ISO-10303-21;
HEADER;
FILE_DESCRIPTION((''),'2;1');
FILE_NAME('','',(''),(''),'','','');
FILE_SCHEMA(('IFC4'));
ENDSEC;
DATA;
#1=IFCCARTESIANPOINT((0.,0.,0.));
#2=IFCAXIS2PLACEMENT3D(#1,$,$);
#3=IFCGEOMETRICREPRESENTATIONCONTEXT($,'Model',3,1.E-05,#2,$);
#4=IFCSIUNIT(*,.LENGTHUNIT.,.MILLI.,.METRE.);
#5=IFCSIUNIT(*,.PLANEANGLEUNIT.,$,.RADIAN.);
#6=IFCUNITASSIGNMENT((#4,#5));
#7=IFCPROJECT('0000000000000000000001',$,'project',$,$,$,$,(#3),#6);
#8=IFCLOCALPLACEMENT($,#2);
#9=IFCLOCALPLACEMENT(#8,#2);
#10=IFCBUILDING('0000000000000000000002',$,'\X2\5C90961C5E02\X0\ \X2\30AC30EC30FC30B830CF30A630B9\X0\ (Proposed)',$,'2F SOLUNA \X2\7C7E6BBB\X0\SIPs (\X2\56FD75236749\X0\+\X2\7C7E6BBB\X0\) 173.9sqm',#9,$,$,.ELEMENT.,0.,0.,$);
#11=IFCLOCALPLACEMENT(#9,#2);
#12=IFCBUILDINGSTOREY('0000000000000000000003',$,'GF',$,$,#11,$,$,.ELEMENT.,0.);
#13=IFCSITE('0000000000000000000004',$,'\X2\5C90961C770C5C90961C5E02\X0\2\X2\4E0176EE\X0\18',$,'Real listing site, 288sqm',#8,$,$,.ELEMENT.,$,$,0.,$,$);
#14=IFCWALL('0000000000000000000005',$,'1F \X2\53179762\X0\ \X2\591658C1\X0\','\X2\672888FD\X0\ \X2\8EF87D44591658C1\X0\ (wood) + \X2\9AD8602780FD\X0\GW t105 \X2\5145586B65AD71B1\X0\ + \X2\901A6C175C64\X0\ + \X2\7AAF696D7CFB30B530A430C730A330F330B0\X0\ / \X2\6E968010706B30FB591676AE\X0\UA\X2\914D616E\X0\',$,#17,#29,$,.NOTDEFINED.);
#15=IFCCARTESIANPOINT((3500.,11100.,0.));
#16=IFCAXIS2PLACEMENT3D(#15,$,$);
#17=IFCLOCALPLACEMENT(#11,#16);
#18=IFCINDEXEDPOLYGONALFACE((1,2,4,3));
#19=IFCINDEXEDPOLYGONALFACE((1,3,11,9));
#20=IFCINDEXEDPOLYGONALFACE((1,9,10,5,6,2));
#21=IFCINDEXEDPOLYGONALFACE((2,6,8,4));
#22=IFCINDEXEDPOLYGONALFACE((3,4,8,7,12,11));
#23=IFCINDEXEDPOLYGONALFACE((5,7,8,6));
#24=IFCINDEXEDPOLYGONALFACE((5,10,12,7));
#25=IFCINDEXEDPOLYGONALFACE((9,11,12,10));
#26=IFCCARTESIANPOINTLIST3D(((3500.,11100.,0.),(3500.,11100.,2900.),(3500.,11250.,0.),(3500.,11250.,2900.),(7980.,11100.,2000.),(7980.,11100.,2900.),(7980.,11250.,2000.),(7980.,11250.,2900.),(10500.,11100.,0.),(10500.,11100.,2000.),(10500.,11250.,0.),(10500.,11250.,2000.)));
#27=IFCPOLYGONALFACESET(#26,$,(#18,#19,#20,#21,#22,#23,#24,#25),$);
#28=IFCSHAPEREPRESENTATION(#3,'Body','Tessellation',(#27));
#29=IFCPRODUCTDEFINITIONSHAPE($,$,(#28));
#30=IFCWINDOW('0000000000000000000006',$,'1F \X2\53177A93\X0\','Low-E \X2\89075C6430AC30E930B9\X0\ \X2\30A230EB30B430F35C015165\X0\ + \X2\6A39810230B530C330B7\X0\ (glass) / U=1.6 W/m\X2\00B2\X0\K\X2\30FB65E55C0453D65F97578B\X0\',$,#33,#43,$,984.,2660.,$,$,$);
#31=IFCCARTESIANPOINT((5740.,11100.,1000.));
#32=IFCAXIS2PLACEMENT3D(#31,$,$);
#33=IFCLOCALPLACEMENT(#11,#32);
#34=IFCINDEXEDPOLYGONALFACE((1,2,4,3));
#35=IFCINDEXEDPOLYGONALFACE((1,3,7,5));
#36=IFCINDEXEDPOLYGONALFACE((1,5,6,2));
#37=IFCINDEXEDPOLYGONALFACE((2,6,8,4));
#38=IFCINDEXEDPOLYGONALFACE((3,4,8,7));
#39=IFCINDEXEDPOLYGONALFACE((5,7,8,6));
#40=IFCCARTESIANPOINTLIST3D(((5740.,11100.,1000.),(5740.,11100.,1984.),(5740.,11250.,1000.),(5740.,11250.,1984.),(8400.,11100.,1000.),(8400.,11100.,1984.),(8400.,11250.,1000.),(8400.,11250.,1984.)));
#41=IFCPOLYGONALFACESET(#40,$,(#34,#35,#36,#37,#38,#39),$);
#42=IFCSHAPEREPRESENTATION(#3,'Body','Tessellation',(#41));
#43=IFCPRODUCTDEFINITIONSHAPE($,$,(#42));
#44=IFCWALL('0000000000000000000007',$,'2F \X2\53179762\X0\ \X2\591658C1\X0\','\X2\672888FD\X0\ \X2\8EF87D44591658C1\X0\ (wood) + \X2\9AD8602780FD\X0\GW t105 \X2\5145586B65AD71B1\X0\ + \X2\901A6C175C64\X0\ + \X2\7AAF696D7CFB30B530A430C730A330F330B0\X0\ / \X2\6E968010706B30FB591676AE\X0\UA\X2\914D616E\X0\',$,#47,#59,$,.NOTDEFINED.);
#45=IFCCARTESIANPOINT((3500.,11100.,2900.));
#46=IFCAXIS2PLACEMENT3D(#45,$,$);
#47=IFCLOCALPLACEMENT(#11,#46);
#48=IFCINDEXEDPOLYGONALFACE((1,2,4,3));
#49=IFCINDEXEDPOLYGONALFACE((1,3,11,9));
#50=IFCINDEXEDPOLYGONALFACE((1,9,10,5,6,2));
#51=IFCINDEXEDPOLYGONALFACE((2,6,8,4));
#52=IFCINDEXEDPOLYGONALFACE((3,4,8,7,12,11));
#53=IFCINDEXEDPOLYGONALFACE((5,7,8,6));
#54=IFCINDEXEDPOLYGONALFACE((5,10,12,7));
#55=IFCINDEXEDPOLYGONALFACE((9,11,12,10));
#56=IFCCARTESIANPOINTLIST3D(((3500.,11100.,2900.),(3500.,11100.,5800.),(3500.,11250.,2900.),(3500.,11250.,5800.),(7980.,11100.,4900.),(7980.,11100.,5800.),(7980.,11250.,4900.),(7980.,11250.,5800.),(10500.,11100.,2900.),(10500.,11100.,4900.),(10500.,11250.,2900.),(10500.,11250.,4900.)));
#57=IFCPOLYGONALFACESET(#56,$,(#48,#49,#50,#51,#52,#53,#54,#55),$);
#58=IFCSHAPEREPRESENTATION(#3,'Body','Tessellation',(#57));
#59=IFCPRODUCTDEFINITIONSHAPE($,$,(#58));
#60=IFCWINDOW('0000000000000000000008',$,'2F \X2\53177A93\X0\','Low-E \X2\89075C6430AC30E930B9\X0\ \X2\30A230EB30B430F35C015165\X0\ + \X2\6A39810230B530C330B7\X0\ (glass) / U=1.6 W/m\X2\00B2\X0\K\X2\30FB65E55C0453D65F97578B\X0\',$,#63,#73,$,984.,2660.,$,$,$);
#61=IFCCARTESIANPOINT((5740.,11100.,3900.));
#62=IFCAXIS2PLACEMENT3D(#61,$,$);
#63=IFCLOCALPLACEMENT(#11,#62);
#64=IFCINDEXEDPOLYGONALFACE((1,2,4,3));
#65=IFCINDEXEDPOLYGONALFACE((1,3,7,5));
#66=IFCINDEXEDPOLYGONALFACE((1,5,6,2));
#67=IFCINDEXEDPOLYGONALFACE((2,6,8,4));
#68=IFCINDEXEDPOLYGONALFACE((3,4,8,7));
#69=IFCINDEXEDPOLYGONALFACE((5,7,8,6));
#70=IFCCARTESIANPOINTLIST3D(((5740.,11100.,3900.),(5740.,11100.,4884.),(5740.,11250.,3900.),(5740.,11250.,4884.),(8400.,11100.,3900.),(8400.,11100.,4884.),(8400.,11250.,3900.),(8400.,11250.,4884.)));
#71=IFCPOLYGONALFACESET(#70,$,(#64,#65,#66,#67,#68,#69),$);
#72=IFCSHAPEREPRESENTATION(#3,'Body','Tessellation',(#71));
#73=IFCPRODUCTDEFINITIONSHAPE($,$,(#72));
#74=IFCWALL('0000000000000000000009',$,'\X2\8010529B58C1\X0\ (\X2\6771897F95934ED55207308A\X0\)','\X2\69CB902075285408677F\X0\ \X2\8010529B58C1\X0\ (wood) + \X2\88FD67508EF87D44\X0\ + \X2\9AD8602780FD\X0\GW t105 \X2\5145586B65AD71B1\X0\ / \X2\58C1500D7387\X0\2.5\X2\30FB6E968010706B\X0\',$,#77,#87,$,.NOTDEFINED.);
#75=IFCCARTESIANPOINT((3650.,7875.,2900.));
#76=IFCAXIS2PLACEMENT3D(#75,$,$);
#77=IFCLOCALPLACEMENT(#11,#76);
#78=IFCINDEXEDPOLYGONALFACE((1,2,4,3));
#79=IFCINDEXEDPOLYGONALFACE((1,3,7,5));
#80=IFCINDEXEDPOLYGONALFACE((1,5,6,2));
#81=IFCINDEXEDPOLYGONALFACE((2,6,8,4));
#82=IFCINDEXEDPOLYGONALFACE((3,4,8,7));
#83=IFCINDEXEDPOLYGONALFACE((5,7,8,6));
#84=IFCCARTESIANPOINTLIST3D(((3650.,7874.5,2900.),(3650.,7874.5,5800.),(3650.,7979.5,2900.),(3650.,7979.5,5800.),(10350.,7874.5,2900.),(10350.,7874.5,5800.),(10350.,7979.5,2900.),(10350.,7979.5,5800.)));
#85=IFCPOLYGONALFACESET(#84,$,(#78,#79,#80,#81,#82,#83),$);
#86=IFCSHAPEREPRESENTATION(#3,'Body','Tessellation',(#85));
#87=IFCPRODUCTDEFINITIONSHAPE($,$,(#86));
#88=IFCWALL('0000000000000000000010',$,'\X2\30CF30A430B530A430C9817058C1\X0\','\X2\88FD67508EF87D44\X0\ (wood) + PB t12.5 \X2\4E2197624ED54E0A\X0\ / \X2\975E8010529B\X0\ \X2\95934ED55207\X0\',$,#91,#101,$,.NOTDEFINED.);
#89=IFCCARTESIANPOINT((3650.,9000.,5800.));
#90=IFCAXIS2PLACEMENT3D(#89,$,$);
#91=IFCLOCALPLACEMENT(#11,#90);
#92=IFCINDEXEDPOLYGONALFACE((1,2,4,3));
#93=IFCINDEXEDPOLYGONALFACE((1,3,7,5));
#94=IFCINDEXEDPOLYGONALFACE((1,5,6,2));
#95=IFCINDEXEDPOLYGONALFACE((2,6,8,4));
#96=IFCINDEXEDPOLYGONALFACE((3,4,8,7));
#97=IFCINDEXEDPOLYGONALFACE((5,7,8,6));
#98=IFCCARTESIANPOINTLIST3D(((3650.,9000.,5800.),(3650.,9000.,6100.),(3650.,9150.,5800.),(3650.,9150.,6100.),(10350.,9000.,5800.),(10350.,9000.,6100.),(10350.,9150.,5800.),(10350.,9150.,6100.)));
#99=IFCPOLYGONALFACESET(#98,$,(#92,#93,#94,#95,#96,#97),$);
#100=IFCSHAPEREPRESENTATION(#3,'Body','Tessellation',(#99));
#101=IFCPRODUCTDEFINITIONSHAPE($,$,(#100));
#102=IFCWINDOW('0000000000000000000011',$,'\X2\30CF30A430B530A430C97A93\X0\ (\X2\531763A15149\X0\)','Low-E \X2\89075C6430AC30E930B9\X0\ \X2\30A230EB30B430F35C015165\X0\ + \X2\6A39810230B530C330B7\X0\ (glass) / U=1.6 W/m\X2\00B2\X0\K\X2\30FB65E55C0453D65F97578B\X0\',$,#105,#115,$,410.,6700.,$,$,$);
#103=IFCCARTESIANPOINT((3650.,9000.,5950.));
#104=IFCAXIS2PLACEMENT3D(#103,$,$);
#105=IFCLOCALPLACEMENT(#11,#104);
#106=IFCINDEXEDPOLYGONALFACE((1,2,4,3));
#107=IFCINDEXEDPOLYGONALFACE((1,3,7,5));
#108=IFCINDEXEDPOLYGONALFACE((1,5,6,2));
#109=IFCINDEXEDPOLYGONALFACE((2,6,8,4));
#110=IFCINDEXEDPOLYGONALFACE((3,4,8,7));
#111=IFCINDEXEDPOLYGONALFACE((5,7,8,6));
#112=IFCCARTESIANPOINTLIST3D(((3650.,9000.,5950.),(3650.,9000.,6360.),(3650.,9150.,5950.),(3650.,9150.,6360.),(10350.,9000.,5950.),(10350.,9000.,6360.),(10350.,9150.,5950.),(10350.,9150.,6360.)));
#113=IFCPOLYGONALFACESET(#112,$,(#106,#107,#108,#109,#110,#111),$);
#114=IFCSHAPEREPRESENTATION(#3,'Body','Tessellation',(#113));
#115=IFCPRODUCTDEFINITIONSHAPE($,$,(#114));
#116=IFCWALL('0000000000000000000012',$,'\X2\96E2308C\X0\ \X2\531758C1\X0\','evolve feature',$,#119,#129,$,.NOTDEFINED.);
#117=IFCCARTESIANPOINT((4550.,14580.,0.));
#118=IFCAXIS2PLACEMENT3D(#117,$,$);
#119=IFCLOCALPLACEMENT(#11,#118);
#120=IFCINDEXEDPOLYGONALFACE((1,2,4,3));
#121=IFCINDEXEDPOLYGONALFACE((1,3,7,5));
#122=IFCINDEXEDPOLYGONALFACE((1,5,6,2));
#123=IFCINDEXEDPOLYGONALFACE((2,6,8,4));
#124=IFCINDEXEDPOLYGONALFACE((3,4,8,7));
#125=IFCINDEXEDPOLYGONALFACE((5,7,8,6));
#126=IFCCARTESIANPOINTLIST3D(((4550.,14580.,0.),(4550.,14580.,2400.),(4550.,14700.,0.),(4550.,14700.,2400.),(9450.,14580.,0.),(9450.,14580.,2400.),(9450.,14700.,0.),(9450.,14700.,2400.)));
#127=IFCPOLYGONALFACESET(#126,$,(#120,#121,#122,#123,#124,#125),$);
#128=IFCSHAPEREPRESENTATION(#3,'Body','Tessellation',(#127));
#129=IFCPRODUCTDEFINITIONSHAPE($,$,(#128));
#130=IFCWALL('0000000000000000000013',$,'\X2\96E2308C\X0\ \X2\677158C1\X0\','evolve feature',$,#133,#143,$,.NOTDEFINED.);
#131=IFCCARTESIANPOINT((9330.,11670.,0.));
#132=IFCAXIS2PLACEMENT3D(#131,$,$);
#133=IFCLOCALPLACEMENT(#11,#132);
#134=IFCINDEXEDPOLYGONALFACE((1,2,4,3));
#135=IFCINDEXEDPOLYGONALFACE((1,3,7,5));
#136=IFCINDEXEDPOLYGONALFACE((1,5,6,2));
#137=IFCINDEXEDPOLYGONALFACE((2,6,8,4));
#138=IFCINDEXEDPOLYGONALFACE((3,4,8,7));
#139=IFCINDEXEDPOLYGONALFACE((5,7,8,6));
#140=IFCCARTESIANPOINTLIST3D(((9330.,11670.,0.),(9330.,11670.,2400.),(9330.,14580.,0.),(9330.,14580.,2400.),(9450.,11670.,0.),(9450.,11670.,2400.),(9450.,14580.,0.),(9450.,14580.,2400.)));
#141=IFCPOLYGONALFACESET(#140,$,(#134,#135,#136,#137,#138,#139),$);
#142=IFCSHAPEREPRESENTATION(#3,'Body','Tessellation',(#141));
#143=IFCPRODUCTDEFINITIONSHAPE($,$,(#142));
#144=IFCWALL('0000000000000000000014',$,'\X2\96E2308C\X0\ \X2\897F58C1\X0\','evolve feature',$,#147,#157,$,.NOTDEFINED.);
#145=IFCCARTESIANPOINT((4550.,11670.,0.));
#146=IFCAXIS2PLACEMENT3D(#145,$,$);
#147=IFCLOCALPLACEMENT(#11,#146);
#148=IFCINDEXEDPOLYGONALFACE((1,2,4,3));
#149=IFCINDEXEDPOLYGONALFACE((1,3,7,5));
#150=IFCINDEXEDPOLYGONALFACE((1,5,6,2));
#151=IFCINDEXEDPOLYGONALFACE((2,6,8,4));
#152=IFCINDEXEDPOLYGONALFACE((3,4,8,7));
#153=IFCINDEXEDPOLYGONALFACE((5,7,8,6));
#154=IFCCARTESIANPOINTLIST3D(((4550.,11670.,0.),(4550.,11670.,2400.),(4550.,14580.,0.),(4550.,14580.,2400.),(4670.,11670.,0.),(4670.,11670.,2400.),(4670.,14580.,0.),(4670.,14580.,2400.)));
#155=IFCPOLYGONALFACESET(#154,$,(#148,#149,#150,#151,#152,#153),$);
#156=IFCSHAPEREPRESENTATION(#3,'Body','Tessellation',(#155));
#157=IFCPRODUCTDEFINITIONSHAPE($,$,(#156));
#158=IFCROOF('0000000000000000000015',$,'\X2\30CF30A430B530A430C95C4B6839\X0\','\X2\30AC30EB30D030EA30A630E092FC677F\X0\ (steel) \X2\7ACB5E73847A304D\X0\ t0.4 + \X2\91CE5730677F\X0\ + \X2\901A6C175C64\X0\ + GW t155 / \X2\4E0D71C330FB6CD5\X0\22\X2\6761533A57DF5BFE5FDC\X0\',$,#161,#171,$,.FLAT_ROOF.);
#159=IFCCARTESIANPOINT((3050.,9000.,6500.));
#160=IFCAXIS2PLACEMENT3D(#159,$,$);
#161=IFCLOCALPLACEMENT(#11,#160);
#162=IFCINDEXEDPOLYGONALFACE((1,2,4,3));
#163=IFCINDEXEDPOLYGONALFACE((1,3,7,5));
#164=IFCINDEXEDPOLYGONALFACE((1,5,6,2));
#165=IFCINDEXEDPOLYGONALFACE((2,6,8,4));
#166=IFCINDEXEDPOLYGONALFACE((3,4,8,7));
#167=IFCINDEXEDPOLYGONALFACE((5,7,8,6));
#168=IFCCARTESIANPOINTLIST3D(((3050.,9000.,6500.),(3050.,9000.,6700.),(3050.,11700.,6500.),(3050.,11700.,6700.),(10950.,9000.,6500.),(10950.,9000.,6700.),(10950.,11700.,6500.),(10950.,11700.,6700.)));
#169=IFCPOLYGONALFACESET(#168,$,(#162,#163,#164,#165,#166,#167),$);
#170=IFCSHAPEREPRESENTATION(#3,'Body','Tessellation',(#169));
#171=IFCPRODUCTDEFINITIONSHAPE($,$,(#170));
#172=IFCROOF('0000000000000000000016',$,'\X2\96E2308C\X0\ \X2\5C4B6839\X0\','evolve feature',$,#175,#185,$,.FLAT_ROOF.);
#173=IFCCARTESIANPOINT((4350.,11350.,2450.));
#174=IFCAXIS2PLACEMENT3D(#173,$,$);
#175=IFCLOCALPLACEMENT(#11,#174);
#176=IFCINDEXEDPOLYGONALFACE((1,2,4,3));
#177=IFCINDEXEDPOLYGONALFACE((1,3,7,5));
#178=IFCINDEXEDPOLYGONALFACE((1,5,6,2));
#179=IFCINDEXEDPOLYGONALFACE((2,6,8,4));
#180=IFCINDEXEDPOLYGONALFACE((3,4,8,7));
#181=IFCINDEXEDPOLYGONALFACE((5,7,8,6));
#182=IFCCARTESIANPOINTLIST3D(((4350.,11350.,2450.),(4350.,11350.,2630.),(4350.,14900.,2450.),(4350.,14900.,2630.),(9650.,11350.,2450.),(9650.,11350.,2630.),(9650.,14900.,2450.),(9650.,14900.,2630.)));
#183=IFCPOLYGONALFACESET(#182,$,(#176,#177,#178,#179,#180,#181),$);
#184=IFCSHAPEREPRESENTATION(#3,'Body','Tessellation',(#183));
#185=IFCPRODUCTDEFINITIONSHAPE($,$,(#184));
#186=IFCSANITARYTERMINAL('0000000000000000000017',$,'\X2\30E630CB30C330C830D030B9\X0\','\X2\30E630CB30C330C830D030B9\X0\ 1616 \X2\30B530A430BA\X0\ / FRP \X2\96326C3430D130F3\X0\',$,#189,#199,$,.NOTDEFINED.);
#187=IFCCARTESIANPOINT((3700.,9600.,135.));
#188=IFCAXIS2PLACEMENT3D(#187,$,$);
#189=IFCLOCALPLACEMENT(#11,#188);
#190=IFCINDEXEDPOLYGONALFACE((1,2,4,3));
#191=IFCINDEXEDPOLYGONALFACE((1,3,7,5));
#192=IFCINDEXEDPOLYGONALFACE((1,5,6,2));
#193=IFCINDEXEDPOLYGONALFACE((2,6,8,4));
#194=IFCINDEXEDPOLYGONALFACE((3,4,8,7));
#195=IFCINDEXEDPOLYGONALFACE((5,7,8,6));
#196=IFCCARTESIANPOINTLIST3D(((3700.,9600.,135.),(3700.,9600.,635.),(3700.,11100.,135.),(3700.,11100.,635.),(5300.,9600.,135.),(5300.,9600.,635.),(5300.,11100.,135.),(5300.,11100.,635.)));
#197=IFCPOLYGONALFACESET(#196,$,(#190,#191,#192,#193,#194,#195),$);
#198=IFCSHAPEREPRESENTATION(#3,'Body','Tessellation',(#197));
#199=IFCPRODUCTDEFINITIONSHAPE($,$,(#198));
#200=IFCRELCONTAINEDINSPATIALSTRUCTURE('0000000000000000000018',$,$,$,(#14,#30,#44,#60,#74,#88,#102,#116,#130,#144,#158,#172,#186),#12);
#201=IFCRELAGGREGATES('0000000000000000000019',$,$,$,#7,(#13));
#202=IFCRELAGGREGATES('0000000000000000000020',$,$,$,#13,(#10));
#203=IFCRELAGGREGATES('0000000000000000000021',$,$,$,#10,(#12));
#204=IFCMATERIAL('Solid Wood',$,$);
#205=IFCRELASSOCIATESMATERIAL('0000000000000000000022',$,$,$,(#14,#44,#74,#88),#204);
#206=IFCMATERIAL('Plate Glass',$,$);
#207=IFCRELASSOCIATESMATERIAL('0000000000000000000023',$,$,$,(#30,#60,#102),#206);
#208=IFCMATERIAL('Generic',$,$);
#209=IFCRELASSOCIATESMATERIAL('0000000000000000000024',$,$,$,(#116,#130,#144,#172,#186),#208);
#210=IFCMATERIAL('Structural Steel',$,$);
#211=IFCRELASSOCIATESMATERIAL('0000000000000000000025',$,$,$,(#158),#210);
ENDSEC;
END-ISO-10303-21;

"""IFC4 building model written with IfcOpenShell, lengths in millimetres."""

from ifc_helpers import new_model, si_unit, frame, frame_2d, origin, place, context, project, spatial, rectangle, extrude, material, element, fill, save


model = new_model("IFC4")

# Units and contexts
model_context = context("Model", 3, precision=1e-05, world=origin())
ifc_project = project(units=[si_unit("LENGTHUNIT", "METRE", prefix="MILLI"), si_unit("PLANEANGLEUNIT", "RADIAN")], contexts=[model_context])

# Site, building, storey
site_placement = place(None, origin())
site = spatial("IfcSite", under=ifc_project, at=site_placement, Name="岐阜県岐阜市2丁目18", ObjectType="Real listing site, 288sqm", CompositionType="ELEMENT", RefElevation=0.0)
building_placement = place(site_placement, origin())
building = spatial("IfcBuilding", under=site, at=building_placement, Name="岐阜市 ガレージハウス (Proposed)", ObjectType="2F SOLUNA 籾殻SIPs (国産杉+籾殻) 173.9sqm", CompositionType="ELEMENT", ElevationOfRefHeight=0.0, ElevationOfTerrain=0.0)
storey_placement = place(building_placement, origin())
storey = spatial("IfcBuildingStorey", under=building, at=storey_placement, Name="GF", CompositionType="ELEMENT", Elevation=0.0)

# Shared definitions
ifc_material_1 = material(Name="Generic")

# Wall, opening, window
ifc_material_2 = material(Name="Solid Wood")
wall_1_placement = place(storey_placement, frame((3500.0, 11100.0, 0.0)))
wall_1 = element("IfcWall", 1, at=wall_1_placement, inside=storey, material=ifc_material_2, Name="1F 北面 外壁", Description="木製 軸組外壁 (wood) + 高性能GW t105 充填断熱 + 通気層 + 窯業系サイディング / 準耐火・外皮UA配慮", PredefinedType="NOTDEFINED", context=model_context, shape_type="SweptSolid", body=[
    extrude(rectangle(XDim=7000.0, YDim=150.0, at=frame_2d((3500.0, 75.0))), frame((3500.0, 11100.0, 0.0)), (0.0, 0.0, 1.0), 2900.0),
])
opening_1_placement = place(storey_placement, frame((5740.0, 11100.0, 1000.0)))
opening_1 = element("IfcOpeningElement", 2, at=opening_1_placement, cuts=wall_1, PredefinedType="NOTDEFINED", context=model_context, shape_type="SweptSolid", body=[
    extrude(rectangle(XDim=2660.0, YDim=150.0, at=frame_2d((1330.0, 75.0))), frame((5740.0, 11100.0, 1000.0)), (0.0, 0.0, 1.0), 984.0),
])
ifc_material_3 = material(Name="Plate Glass")
window_1_placement = place(storey_placement, frame((5740.0, 11100.0, 1000.0)))
window_1 = element("IfcWindow", 3, at=window_1_placement, inside=storey, material=ifc_material_3, Name="1F 北窓", Description="Low-E 複層ガラス アルゴン封入 + 樹脂サッシ (glass) / U=1.6 W/m²K・日射取得型", OverallHeight=984.0, OverallWidth=2660.0, context=model_context, shape_type="SweptSolid", body=[
    extrude(rectangle(XDim=2660.0, YDim=150.0, at=frame_2d((1330.0, 75.0))), frame((5740.0, 11100.0, 1000.0)), (0.0, 0.0, 1.0), 984.0),
])
fill(opening_1, window_1)

# Wall, opening, window
wall_2_placement = place(storey_placement, frame((3500.0, 11100.0, 2900.0)))
wall_2 = element("IfcWall", 4, at=wall_2_placement, inside=storey, material=ifc_material_2, Name="2F 北面 外壁", Description="木製 軸組外壁 (wood) + 高性能GW t105 充填断熱 + 通気層 + 窯業系サイディング / 準耐火・外皮UA配慮", PredefinedType="NOTDEFINED", context=model_context, shape_type="SweptSolid", body=[
    extrude(rectangle(XDim=7000.0, YDim=150.0, at=frame_2d((3500.0, 75.0))), frame((3500.0, 11100.0, 2900.0)), (0.0, 0.0, 1.0), 2900.0),
])
opening_2_placement = place(storey_placement, frame((5740.0, 11100.0, 3900.0)))
opening_2 = element("IfcOpeningElement", 5, at=opening_2_placement, cuts=wall_2, PredefinedType="NOTDEFINED", context=model_context, shape_type="SweptSolid", body=[
    extrude(rectangle(XDim=2660.0, YDim=150.0, at=frame_2d((1330.0, 75.0))), frame((5740.0, 11100.0, 3900.0)), (0.0, 0.0, 1.0), 984.0),
])
window_2_placement = place(storey_placement, frame((5740.0, 11100.0, 3900.0)))
window_2 = element("IfcWindow", 6, at=window_2_placement, inside=storey, material=ifc_material_3, Name="2F 北窓", Description="Low-E 複層ガラス アルゴン封入 + 樹脂サッシ (glass) / U=1.6 W/m²K・日射取得型", OverallHeight=984.0, OverallWidth=2660.0, context=model_context, shape_type="SweptSolid", body=[
    extrude(rectangle(XDim=2660.0, YDim=150.0, at=frame_2d((1330.0, 75.0))), frame((5740.0, 11100.0, 3900.0)), (0.0, 0.0, 1.0), 984.0),
])
fill(opening_2, window_2)

# Wall
wall_3_placement = place(storey_placement, frame((3650.0, 7875.0, 2900.0)))
element("IfcWall", 7, at=wall_3_placement, inside=storey, material=ifc_material_2, Name="耐力壁 (東西間仕切り)", Description="構造用合板 耐力壁 (wood) + 製材軸組 + 高性能GW t105 充填断熱 / 壁倍率2.5・準耐火", PredefinedType="NOTDEFINED", context=model_context, shape_type="SweptSolid", body=[
    extrude(rectangle(XDim=6700.0, YDim=105.0, at=frame_2d((3350.0, 52.0))), frame((3650.0, 7875.0, 2900.0)), (0.0, 0.0, 1.0), 2900.0),
])

# Wall, opening, window
wall_4_placement = place(storey_placement, frame((3650.0, 9000.0, 5800.0)))
wall_4 = element("IfcWall", 8, at=wall_4_placement, inside=storey, material=ifc_material_2, Name="ハイサイド腰壁", Description="製材軸組 (wood) + PB t12.5 両面仕上 / 非耐力 間仕切", PredefinedType="NOTDEFINED", context=model_context, shape_type="SweptSolid", body=[
    extrude(rectangle(XDim=6700.0, YDim=150.0, at=frame_2d((3350.0, 75.0))), frame((3650.0, 9000.0, 5800.0)), (0.0, 0.0, 1.0), 700.0),
])
opening_3_placement = place(storey_placement, frame((3650.0, 9000.0, 5950.0)))
opening_3 = element("IfcOpeningElement", 9, at=opening_3_placement, cuts=wall_4, PredefinedType="NOTDEFINED", context=model_context, shape_type="SweptSolid", body=[
    extrude(rectangle(XDim=6700.0, YDim=150.0, at=frame_2d((3350.0, 75.0))), frame((3650.0, 9000.0, 5950.0)), (0.0, 0.0, 1.0), 410.0),
])
window_3_placement = place(storey_placement, frame((3650.0, 9000.0, 5950.0)))
window_3 = element("IfcWindow", 10, at=window_3_placement, inside=storey, material=ifc_material_3, Name="ハイサイド窓 (北採光)", Description="Low-E 複層ガラス アルゴン封入 + 樹脂サッシ (glass) / U=1.6 W/m²K・日射取得型", OverallHeight=410.0, OverallWidth=6700.0, context=model_context, shape_type="SweptSolid", body=[
    extrude(rectangle(XDim=6700.0, YDim=150.0, at=frame_2d((3350.0, 75.0))), frame((3650.0, 9000.0, 5950.0)), (0.0, 0.0, 1.0), 410.0),
])
fill(opening_3, window_3)

# Walls
wall_5_placement = place(storey_placement, frame((4550.0, 14580.0, 0.0)))
element("IfcWall", 11, at=wall_5_placement, inside=storey, material=ifc_material_1, Name="離れ 北壁", Description="evolve feature", PredefinedType="NOTDEFINED", context=model_context, shape_type="SweptSolid", body=[
    extrude(rectangle(XDim=4900.0, YDim=120.0, at=frame_2d((2450.0, 60.0))), frame((4550.0, 14580.0, 0.0)), (0.0, 0.0, 1.0), 2400.0),
])
wall_6_placement = place(storey_placement, frame((9330.0, 11670.0, 0.0)))
element("IfcWall", 12, at=wall_6_placement, inside=storey, material=ifc_material_1, Name="離れ 東壁", Description="evolve feature", PredefinedType="NOTDEFINED", context=model_context, shape_type="SweptSolid", body=[
    extrude(rectangle(XDim=120.0, YDim=2910.0, at=frame_2d((60.0, 1455.0))), frame((9330.0, 11670.0, 0.0)), (0.0, 0.0, 1.0), 2400.0),
])
wall_7_placement = place(storey_placement, frame((4550.0, 11670.0, 0.0)))
element("IfcWall", 13, at=wall_7_placement, inside=storey, material=ifc_material_1, Name="離れ 西壁", Description="evolve feature", PredefinedType="NOTDEFINED", context=model_context, shape_type="SweptSolid", body=[
    extrude(rectangle(XDim=120.0, YDim=2910.0, at=frame_2d((60.0, 1455.0))), frame((4550.0, 11670.0, 0.0)), (0.0, 0.0, 1.0), 2400.0),
])

# Roofs
ifc_material_4 = material(Name="Structural Steel")
roof_1_placement = place(storey_placement, frame((3050.0, 9000.0, 6500.0)))
element("IfcRoof", 14, at=roof_1_placement, inside=storey, material=ifc_material_4, Name="ハイサイド屋根", Description="ガルバリウム鋼板 (steel) 立平葺き t0.4 + 野地板 + 通気層 + GW t155 / 不燃・法22条区域対応", PredefinedType="FLAT_ROOF", context=model_context, shape_type="SweptSolid", body=[
    extrude(rectangle(XDim=7900.0, YDim=2700.0, at=frame_2d((3950.0, 1350.0))), frame((3050.0, 9000.0, 6500.0)), (0.0, 0.0, 1.0), 200.0),
])
roof_2_placement = place(storey_placement, frame((4350.0, 11350.0, 2450.0)))
element("IfcRoof", 15, at=roof_2_placement, inside=storey, material=ifc_material_1, Name="離れ 屋根", Description="evolve feature", PredefinedType="FLAT_ROOF", context=model_context, shape_type="SweptSolid", body=[
    extrude(rectangle(XDim=5300.0, YDim=3550.0, at=frame_2d((2650.0, 1775.0))), frame((4350.0, 11350.0, 2450.0)), (0.0, 0.0, 1.0), 180.0),
])

# Sanitary terminal
sanitary_terminal_1_placement = place(storey_placement, frame((3700.0, 9600.0, 135.0)))
element("IfcSanitaryTerminal", 16, at=sanitary_terminal_1_placement, inside=storey, material=ifc_material_1, Name="ユニットバス", Description="ユニットバス 1616 サイズ / FRP 防水パン", PredefinedType="NOTDEFINED", context=model_context, shape_type="SweptSolid", body=[
    extrude(rectangle(XDim=1600.0, YDim=1500.0, at=frame_2d((800.0, 750.0))), frame((3700.0, 9600.0, 135.0)), (0.0, 0.0, 1.0), 500.0),
])

save(model, "model.ifc")
